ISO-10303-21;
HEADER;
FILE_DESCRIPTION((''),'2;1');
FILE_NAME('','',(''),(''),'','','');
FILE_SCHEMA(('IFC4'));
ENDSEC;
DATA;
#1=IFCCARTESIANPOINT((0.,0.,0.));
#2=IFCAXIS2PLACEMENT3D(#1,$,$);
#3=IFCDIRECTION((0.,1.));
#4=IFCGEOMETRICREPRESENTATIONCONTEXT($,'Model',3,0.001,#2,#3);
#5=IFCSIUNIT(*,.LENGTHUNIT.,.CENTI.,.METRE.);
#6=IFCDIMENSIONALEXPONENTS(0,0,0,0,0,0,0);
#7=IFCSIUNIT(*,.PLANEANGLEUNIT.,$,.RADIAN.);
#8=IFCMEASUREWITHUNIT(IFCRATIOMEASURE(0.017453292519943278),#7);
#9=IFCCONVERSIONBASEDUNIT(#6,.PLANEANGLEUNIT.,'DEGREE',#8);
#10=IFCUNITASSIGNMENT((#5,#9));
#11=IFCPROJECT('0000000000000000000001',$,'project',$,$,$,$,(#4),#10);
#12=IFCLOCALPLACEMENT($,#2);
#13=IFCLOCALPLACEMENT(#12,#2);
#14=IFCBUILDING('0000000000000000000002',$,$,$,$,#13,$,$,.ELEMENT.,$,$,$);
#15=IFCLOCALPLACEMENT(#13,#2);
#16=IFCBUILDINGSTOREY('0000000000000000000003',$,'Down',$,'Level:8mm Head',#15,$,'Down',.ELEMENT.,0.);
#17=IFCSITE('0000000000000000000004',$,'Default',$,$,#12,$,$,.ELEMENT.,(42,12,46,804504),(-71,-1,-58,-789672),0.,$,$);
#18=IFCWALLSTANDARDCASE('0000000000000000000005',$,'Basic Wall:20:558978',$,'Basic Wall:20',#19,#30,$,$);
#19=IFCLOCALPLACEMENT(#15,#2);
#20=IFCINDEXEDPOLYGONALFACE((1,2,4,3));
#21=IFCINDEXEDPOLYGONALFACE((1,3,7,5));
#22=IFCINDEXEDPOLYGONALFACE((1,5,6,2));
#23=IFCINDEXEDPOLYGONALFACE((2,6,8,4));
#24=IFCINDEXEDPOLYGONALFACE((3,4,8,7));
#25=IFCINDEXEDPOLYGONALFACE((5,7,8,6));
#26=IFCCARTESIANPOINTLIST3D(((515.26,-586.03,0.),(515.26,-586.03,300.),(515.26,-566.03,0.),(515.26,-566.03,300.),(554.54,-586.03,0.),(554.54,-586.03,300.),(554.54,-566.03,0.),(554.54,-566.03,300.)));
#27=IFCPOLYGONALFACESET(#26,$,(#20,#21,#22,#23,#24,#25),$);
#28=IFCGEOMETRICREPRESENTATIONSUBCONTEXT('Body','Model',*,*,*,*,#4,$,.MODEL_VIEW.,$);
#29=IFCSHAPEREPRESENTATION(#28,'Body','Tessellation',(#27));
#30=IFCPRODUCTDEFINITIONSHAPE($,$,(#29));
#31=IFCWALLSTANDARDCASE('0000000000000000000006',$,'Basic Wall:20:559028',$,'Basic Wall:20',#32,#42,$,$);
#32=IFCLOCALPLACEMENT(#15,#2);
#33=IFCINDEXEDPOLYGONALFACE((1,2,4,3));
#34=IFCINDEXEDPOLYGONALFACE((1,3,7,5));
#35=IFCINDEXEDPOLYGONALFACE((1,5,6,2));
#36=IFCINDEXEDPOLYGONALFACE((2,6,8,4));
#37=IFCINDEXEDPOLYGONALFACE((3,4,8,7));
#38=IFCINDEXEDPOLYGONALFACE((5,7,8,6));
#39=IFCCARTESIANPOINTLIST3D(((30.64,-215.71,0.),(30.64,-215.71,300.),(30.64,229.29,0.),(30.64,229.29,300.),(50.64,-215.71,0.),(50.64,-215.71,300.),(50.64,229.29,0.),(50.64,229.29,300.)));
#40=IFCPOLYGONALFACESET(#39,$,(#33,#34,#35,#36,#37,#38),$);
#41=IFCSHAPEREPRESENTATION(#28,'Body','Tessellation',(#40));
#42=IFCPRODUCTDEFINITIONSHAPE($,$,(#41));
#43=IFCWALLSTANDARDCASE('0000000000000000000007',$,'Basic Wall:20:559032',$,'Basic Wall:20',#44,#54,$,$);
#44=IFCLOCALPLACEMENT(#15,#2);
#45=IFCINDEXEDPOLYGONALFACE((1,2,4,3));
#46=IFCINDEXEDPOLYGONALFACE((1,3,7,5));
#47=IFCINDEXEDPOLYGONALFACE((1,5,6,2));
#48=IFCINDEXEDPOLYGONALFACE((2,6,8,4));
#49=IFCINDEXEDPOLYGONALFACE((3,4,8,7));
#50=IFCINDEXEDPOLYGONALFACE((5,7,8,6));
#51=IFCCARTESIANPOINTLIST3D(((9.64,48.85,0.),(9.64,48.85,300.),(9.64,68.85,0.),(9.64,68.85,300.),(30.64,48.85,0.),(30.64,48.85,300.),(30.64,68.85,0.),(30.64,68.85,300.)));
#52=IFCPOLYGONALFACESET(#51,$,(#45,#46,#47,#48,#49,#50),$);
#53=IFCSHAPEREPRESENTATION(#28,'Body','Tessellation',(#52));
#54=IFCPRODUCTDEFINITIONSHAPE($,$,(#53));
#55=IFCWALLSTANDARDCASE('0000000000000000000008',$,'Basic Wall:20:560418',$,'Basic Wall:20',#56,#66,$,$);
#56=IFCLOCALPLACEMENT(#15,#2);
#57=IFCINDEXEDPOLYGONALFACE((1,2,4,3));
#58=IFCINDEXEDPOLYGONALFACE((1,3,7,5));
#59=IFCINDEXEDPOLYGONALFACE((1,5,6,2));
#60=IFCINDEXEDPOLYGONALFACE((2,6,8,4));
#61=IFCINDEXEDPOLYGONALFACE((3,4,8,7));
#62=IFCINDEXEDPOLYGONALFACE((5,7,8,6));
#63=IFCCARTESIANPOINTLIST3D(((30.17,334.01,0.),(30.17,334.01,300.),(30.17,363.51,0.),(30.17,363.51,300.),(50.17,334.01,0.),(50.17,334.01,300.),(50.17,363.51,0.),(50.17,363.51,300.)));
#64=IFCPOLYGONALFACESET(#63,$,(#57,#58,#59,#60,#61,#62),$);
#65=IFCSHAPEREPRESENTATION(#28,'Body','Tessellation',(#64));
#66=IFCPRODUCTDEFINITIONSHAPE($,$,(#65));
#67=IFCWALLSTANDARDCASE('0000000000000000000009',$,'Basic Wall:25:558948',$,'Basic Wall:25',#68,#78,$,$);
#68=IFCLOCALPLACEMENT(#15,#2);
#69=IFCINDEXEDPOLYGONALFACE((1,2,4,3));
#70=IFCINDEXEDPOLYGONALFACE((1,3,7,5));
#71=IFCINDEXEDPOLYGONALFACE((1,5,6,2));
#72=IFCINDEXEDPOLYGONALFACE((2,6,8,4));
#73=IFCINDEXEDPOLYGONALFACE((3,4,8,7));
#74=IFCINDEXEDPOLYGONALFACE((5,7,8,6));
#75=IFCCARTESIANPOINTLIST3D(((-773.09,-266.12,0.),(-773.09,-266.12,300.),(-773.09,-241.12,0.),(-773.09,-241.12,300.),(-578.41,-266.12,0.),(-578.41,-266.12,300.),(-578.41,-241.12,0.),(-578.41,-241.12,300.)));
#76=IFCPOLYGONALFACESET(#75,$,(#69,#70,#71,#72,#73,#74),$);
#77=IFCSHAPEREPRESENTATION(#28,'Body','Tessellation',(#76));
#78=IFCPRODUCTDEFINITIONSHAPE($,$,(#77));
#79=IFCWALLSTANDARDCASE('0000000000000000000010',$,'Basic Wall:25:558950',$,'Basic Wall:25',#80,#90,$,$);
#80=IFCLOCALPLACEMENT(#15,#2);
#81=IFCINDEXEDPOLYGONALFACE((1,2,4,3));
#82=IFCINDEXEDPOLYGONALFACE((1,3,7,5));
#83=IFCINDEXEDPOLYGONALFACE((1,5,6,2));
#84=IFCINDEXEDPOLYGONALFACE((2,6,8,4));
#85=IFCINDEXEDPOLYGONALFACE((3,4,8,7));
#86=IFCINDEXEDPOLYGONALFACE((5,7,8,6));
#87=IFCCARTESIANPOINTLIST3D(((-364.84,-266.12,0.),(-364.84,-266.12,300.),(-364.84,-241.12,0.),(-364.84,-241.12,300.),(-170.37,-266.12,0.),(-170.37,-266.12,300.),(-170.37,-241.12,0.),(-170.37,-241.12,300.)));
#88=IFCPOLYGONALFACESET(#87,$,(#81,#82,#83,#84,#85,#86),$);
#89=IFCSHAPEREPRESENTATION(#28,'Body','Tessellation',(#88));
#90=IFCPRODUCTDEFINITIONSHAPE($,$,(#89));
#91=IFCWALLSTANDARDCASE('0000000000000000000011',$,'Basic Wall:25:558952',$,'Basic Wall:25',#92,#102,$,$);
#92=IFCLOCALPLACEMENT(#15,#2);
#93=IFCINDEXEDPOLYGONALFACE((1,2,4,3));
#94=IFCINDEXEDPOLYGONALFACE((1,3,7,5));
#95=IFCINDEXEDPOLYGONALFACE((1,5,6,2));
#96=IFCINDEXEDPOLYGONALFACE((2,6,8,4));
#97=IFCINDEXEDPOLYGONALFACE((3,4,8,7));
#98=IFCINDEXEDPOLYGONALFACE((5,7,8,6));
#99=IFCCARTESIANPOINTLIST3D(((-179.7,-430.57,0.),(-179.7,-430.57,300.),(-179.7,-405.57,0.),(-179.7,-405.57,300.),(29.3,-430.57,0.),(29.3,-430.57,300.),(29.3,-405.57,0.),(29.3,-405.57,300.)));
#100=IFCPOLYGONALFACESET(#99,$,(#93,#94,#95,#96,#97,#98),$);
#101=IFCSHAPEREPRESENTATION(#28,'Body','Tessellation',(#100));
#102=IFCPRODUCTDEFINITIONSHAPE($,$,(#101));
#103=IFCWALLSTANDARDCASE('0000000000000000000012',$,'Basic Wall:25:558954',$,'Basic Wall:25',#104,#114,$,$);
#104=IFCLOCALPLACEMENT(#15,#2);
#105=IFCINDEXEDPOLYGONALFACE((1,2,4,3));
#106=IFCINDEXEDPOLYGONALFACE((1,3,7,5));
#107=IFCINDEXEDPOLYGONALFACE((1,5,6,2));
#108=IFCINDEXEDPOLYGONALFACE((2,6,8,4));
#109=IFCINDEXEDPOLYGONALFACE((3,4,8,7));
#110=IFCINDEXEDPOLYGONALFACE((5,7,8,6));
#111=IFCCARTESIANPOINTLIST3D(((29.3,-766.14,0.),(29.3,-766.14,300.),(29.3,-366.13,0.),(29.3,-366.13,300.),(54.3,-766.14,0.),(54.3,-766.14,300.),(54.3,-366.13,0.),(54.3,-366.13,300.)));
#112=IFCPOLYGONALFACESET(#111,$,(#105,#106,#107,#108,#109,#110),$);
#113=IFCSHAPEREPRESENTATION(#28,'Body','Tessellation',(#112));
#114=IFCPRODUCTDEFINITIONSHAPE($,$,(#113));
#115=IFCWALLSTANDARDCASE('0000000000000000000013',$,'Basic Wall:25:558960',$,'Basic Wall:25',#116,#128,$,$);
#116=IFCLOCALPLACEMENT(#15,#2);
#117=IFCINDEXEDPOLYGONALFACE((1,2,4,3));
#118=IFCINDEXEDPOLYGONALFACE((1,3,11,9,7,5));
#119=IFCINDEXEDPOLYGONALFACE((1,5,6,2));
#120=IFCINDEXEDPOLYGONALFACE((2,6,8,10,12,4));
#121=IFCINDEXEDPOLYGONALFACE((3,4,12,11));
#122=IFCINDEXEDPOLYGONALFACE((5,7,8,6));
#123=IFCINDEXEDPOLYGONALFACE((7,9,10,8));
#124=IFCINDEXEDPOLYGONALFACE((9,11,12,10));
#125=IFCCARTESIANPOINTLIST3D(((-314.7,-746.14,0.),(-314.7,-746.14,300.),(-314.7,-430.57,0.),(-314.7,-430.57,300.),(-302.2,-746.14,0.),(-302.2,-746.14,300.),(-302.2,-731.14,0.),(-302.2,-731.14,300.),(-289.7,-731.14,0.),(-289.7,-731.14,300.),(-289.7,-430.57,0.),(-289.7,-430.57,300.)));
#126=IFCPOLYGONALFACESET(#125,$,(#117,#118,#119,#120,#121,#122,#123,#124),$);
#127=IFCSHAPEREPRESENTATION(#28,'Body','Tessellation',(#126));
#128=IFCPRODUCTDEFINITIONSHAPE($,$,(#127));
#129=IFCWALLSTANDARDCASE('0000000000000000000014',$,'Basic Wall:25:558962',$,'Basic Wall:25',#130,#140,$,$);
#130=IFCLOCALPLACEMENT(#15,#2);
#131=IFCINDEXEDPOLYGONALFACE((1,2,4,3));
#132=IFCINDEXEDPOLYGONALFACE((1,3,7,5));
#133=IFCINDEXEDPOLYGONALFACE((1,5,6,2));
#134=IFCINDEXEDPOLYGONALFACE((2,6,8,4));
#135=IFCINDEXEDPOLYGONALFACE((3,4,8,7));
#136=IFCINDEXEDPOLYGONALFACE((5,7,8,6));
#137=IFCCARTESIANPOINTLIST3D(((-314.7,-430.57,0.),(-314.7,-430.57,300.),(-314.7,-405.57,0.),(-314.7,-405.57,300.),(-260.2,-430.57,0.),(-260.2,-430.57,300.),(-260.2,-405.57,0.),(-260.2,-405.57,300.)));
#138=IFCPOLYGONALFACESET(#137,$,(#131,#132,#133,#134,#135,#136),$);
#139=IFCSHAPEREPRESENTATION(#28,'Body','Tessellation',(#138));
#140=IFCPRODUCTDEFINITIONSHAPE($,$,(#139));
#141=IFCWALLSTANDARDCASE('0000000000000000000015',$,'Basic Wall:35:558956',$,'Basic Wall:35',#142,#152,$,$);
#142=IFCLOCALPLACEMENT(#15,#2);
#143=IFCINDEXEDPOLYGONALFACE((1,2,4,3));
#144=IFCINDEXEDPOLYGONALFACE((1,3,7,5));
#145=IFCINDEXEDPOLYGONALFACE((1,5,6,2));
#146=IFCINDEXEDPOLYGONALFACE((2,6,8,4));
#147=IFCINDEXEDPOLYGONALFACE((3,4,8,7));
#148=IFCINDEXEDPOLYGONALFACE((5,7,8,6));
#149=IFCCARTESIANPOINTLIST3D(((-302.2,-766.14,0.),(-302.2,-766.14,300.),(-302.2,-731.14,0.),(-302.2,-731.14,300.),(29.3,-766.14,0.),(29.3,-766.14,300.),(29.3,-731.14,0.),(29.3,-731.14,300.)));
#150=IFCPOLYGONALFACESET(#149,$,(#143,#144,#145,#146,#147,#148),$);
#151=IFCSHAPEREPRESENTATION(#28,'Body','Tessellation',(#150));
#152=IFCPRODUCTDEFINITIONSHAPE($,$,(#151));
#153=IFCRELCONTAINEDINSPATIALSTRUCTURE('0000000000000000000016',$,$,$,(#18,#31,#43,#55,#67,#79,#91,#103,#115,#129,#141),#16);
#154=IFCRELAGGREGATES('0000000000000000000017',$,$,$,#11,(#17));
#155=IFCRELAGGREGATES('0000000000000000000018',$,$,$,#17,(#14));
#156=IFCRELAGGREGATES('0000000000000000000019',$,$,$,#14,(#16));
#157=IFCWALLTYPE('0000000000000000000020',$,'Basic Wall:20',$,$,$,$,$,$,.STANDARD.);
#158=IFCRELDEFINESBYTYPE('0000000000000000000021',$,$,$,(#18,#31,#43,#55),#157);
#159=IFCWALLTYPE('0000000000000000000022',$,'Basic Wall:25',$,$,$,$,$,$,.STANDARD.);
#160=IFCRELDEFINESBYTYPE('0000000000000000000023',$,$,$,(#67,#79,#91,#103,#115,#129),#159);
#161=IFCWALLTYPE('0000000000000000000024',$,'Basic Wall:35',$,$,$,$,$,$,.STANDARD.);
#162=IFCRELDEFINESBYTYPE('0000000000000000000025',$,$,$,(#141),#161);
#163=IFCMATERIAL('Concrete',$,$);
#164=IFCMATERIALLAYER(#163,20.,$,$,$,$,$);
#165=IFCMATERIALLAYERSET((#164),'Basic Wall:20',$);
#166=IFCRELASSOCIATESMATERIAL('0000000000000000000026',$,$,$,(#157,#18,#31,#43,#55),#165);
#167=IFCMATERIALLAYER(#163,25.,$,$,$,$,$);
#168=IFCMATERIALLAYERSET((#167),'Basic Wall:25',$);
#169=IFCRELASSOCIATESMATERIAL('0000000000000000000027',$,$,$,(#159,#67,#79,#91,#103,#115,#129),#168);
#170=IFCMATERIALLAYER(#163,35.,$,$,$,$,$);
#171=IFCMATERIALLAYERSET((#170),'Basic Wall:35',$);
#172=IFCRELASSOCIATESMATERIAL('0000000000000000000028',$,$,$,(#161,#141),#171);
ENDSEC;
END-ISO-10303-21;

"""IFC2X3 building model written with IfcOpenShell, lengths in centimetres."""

from ifc_helpers import new_model, entity, si_unit, converted_unit, direction, frame, frame_2d, origin, place, context, subcontext, project, spatial, polyline, rectangle, outline, extrude, material, layer, layer_set, layer_usage, type_object, element, save


model = new_model("IFC2X3")

# Units and contexts
model_context = context("Model", 3, precision=0.001, world=origin(), true_north=direction((0.0, 1.0)))
body_context = subcontext(model_context, "Body", "Model", "MODEL_VIEW")
ifc_project = project(units=[si_unit("LENGTHUNIT", "METRE", prefix="CENTI"), converted_unit("PLANEANGLEUNIT", "DEGREE", entity("IfcRatioMeasure", 0.017453292519943278), si_unit("PLANEANGLEUNIT", "RADIAN"), dimensions=[0, 0, 0, 0, 0, 0, 0])], contexts=[model_context])

# Site, building, storey
site_placement = place(None, origin())
site = spatial("IfcSite", under=ifc_project, at=site_placement, Name="Default", CompositionType="ELEMENT", RefLatitude=(42, 12, 46, 804504), RefLongitude=(-71, -1, -58, -789672), RefElevation=0.0)
building_placement = place(site_placement, origin())
building = spatial("IfcBuilding", under=site, at=building_placement, CompositionType="ELEMENT")
storey_placement = place(building_placement, origin())
storey = spatial("IfcBuildingStorey", under=building, at=storey_placement, Name="Down", ObjectType="Level:8mm Head", LongName="Down", CompositionType="ELEMENT", Elevation=0.0)

# Shared definitions
ifc_material = material(Name="Concrete")

# Walls
ifc_layer_1 = layer(ifc_material, 20.0)
ifc_layer_set_1 = layer_set([ifc_layer_1], Name="Basic Wall:20")
wall_type_1 = type_object("IfcWallType", Name="Basic Wall:20", PredefinedType="STANDARD", material=ifc_layer_set_1)
ifc_layer_usage_1 = layer_usage(ifc_layer_set_1, "AXIS2", "NEGATIVE", 10.0)
wall_1_placement = place(storey_placement, frame((515.26, -576.03, 0.0)))
element("IfcWallStandardCase", 1, at=wall_1_placement, inside=storey, type_object=wall_type_1, material=ifc_layer_usage_1, Name="Basic Wall:20:558978", ObjectType="Basic Wall:20", context=body_context, shape_type="SweptSolid", body=[
    extrude(rectangle(XDim=39.28, YDim=20.0, at=frame_2d((19.64, 0.0), x_axis=(-1.0, 0.0))), origin(), (0.0, 0.0, 1.0), 300.0),
])
ifc_layer_usage_2 = layer_usage(ifc_layer_set_1, "AXIS2", "NEGATIVE", 10.0)
wall_2_placement = place(storey_placement, frame((40.64, -215.71, 0.0), z_axis=(0.0, 0.0, 1.0), x_axis=(0.0, 1.0, 0.0)))
element("IfcWallStandardCase", 2, at=wall_2_placement, inside=storey, type_object=wall_type_1, material=ifc_layer_usage_2, Name="Basic Wall:20:559028", ObjectType="Basic Wall:20", context=body_context, shape_type="SweptSolid", body=[
    extrude(rectangle(XDim=445.0, YDim=20.0, at=frame_2d((222.5, 0.0), x_axis=(-1.0, 0.0))), origin(), (0.0, 0.0, 1.0), 300.0),
])
ifc_layer_usage_3 = layer_usage(ifc_layer_set_1, "AXIS2", "NEGATIVE", 10.0)
wall_3_placement = place(storey_placement, frame((30.64, 58.85, 0.0), z_axis=(0.0, 0.0, 1.0), x_axis=(-1.0, 0.0, 0.0)))
element("IfcWallStandardCase", 3, at=wall_3_placement, inside=storey, type_object=wall_type_1, material=ifc_layer_usage_3, Name="Basic Wall:20:559032", ObjectType="Basic Wall:20", context=body_context, shape_type="SweptSolid", body=[
    extrude(rectangle(XDim=21.0, YDim=20.0, at=frame_2d((10.5, 0.0), x_axis=(-1.0, 0.0))), origin(), (0.0, 0.0, 1.0), 300.0),
])
ifc_layer_usage_4 = layer_usage(ifc_layer_set_1, "AXIS2", "NEGATIVE", 10.0)
wall_4_placement = place(storey_placement, frame((40.17, 334.01, 0.0), z_axis=(0.0, 0.0, 1.0), x_axis=(0.0, 1.0, 0.0)))
element("IfcWallStandardCase", 4, at=wall_4_placement, inside=storey, type_object=wall_type_1, material=ifc_layer_usage_4, Name="Basic Wall:20:560418", ObjectType="Basic Wall:20", context=body_context, shape_type="SweptSolid", body=[
    extrude(rectangle(XDim=29.5, YDim=20.0, at=frame_2d((14.75, 0.0), x_axis=(-1.0, 0.0))), origin(), (0.0, 0.0, 1.0), 300.0),
])
ifc_layer_2 = layer(ifc_material, 25.0)
ifc_layer_set_2 = layer_set([ifc_layer_2], Name="Basic Wall:25")
ifc_layer_usage_5 = layer_usage(ifc_layer_set_2, "AXIS2", "NEGATIVE", 12.5)
wall_type_2 = type_object("IfcWallType", Name="Basic Wall:25", PredefinedType="STANDARD", material=ifc_layer_set_2)
wall_5_placement = place(storey_placement, frame((-773.09, -253.62, 0.0)))
element("IfcWallStandardCase", 5, at=wall_5_placement, inside=storey, type_object=wall_type_2, material=ifc_layer_usage_5, Name="Basic Wall:25:558948", ObjectType="Basic Wall:25", context=body_context, shape_type="SweptSolid", body=[
    extrude(rectangle(XDim=194.69, YDim=25.0, at=frame_2d((97.34, 0.0), x_axis=(-1.0, 0.0))), origin(), (0.0, 0.0, 1.0), 300.0),
])
ifc_layer_usage_6 = layer_usage(ifc_layer_set_2, "AXIS2", "NEGATIVE", 12.5)
wall_6_placement = place(storey_placement, frame((-364.84, -253.62, 0.0)))
element("IfcWallStandardCase", 6, at=wall_6_placement, inside=storey, type_object=wall_type_2, material=ifc_layer_usage_6, Name="Basic Wall:25:558950", ObjectType="Basic Wall:25", context=body_context, shape_type="SweptSolid", body=[
    extrude(rectangle(XDim=194.47, YDim=25.0, at=frame_2d((97.23, 0.0), x_axis=(-1.0, 0.0))), origin(), (0.0, 0.0, 1.0), 300.0),
])
ifc_layer_usage_7 = layer_usage(ifc_layer_set_2, "AXIS2", "NEGATIVE", 12.5)
wall_7_placement = place(storey_placement, frame((-179.7, -418.07, 0.0)))
element("IfcWallStandardCase", 7, at=wall_7_placement, inside=storey, type_object=wall_type_2, material=ifc_layer_usage_7, Name="Basic Wall:25:558952", ObjectType="Basic Wall:25", context=body_context, shape_type="SweptSolid", body=[
    extrude(rectangle(XDim=209.0, YDim=25.0, at=frame_2d((104.5, 0.0), x_axis=(-1.0, 0.0))), origin(), (0.0, 0.0, 1.0), 300.0),
])
ifc_layer_usage_8 = layer_usage(ifc_layer_set_2, "AXIS2", "NEGATIVE", 12.5)
wall_8_placement = place(storey_placement, frame((41.8, -366.13, 0.0), z_axis=(0.0, 0.0, 1.0), x_axis=(0.0, -1.0, 0.0)))
element("IfcWallStandardCase", 8, at=wall_8_placement, inside=storey, type_object=wall_type_2, material=ifc_layer_usage_8, Name="Basic Wall:25:558954", ObjectType="Basic Wall:25", context=body_context, shape_type="SweptSolid", body=[
    extrude(rectangle(XDim=400.01, YDim=25.0, at=frame_2d((200.0, 0.0), x_axis=(-1.0, 0.0))), origin(), (0.0, 0.0, 1.0), 300.0),
])
ifc_layer_usage_9 = layer_usage(ifc_layer_set_2, "AXIS2", "NEGATIVE", 12.5)
wall_9_placement = place(storey_placement, frame((-302.2, -746.14, 0.0), z_axis=(0.0, 0.0, 1.0), x_axis=(0.0, 1.0, 0.0)))
element("IfcWallStandardCase", 9, at=wall_9_placement, inside=storey, type_object=wall_type_2, material=ifc_layer_usage_9, Name="Basic Wall:25:558960", ObjectType="Basic Wall:25", context=body_context, shape_type="SweptSolid", body=[
    extrude(outline(polyline([(315.57, -12.5), (315.57, 12.5), (0.0, 12.5), (0.0, 0.0), (15.0, 0.0), (15.0, -12.5), (315.57, -12.5)])), origin(), (0.0, 0.0, 1.0), 300.0),
])
ifc_layer_usage_10 = layer_usage(ifc_layer_set_2, "AXIS2", "NEGATIVE", 12.5)
wall_10_placement = place(storey_placement, frame((-314.7, -418.07, 0.0)))
element("IfcWallStandardCase", 10, at=wall_10_placement, inside=storey, type_object=wall_type_2, material=ifc_layer_usage_10, Name="Basic Wall:25:558962", ObjectType="Basic Wall:25", context=body_context, shape_type="SweptSolid", body=[
    extrude(rectangle(XDim=54.5, YDim=25.0, at=frame_2d((27.25, 0.0), x_axis=(-1.0, 0.0))), origin(), (0.0, 0.0, 1.0), 300.0),
])
ifc_layer_3 = layer(ifc_material, 35.0)
ifc_layer_set_3 = layer_set([ifc_layer_3], Name="Basic Wall:35")
ifc_layer_usage_11 = layer_usage(ifc_layer_set_3, "AXIS2", "NEGATIVE", 17.5)
wall_type_3 = type_object("IfcWallType", Name="Basic Wall:35", PredefinedType="STANDARD", material=ifc_layer_set_3)
wall_11_placement = place(storey_placement, frame((29.3, -748.64, 0.0), z_axis=(0.0, 0.0, 1.0), x_axis=(-1.0, 0.0, 0.0)))
element("IfcWallStandardCase", 11, at=wall_11_placement, inside=storey, type_object=wall_type_3, material=ifc_layer_usage_11, Name="Basic Wall:35:558956", ObjectType="Basic Wall:35", context=body_context, shape_type="SweptSolid", body=[
    extrude(rectangle(XDim=331.5, YDim=35.0, at=frame_2d((165.75, 0.0), x_axis=(-1.0, 0.0))), origin(), (0.0, 0.0, 1.0), 300.0),
])

save(model, "model.ifc")
